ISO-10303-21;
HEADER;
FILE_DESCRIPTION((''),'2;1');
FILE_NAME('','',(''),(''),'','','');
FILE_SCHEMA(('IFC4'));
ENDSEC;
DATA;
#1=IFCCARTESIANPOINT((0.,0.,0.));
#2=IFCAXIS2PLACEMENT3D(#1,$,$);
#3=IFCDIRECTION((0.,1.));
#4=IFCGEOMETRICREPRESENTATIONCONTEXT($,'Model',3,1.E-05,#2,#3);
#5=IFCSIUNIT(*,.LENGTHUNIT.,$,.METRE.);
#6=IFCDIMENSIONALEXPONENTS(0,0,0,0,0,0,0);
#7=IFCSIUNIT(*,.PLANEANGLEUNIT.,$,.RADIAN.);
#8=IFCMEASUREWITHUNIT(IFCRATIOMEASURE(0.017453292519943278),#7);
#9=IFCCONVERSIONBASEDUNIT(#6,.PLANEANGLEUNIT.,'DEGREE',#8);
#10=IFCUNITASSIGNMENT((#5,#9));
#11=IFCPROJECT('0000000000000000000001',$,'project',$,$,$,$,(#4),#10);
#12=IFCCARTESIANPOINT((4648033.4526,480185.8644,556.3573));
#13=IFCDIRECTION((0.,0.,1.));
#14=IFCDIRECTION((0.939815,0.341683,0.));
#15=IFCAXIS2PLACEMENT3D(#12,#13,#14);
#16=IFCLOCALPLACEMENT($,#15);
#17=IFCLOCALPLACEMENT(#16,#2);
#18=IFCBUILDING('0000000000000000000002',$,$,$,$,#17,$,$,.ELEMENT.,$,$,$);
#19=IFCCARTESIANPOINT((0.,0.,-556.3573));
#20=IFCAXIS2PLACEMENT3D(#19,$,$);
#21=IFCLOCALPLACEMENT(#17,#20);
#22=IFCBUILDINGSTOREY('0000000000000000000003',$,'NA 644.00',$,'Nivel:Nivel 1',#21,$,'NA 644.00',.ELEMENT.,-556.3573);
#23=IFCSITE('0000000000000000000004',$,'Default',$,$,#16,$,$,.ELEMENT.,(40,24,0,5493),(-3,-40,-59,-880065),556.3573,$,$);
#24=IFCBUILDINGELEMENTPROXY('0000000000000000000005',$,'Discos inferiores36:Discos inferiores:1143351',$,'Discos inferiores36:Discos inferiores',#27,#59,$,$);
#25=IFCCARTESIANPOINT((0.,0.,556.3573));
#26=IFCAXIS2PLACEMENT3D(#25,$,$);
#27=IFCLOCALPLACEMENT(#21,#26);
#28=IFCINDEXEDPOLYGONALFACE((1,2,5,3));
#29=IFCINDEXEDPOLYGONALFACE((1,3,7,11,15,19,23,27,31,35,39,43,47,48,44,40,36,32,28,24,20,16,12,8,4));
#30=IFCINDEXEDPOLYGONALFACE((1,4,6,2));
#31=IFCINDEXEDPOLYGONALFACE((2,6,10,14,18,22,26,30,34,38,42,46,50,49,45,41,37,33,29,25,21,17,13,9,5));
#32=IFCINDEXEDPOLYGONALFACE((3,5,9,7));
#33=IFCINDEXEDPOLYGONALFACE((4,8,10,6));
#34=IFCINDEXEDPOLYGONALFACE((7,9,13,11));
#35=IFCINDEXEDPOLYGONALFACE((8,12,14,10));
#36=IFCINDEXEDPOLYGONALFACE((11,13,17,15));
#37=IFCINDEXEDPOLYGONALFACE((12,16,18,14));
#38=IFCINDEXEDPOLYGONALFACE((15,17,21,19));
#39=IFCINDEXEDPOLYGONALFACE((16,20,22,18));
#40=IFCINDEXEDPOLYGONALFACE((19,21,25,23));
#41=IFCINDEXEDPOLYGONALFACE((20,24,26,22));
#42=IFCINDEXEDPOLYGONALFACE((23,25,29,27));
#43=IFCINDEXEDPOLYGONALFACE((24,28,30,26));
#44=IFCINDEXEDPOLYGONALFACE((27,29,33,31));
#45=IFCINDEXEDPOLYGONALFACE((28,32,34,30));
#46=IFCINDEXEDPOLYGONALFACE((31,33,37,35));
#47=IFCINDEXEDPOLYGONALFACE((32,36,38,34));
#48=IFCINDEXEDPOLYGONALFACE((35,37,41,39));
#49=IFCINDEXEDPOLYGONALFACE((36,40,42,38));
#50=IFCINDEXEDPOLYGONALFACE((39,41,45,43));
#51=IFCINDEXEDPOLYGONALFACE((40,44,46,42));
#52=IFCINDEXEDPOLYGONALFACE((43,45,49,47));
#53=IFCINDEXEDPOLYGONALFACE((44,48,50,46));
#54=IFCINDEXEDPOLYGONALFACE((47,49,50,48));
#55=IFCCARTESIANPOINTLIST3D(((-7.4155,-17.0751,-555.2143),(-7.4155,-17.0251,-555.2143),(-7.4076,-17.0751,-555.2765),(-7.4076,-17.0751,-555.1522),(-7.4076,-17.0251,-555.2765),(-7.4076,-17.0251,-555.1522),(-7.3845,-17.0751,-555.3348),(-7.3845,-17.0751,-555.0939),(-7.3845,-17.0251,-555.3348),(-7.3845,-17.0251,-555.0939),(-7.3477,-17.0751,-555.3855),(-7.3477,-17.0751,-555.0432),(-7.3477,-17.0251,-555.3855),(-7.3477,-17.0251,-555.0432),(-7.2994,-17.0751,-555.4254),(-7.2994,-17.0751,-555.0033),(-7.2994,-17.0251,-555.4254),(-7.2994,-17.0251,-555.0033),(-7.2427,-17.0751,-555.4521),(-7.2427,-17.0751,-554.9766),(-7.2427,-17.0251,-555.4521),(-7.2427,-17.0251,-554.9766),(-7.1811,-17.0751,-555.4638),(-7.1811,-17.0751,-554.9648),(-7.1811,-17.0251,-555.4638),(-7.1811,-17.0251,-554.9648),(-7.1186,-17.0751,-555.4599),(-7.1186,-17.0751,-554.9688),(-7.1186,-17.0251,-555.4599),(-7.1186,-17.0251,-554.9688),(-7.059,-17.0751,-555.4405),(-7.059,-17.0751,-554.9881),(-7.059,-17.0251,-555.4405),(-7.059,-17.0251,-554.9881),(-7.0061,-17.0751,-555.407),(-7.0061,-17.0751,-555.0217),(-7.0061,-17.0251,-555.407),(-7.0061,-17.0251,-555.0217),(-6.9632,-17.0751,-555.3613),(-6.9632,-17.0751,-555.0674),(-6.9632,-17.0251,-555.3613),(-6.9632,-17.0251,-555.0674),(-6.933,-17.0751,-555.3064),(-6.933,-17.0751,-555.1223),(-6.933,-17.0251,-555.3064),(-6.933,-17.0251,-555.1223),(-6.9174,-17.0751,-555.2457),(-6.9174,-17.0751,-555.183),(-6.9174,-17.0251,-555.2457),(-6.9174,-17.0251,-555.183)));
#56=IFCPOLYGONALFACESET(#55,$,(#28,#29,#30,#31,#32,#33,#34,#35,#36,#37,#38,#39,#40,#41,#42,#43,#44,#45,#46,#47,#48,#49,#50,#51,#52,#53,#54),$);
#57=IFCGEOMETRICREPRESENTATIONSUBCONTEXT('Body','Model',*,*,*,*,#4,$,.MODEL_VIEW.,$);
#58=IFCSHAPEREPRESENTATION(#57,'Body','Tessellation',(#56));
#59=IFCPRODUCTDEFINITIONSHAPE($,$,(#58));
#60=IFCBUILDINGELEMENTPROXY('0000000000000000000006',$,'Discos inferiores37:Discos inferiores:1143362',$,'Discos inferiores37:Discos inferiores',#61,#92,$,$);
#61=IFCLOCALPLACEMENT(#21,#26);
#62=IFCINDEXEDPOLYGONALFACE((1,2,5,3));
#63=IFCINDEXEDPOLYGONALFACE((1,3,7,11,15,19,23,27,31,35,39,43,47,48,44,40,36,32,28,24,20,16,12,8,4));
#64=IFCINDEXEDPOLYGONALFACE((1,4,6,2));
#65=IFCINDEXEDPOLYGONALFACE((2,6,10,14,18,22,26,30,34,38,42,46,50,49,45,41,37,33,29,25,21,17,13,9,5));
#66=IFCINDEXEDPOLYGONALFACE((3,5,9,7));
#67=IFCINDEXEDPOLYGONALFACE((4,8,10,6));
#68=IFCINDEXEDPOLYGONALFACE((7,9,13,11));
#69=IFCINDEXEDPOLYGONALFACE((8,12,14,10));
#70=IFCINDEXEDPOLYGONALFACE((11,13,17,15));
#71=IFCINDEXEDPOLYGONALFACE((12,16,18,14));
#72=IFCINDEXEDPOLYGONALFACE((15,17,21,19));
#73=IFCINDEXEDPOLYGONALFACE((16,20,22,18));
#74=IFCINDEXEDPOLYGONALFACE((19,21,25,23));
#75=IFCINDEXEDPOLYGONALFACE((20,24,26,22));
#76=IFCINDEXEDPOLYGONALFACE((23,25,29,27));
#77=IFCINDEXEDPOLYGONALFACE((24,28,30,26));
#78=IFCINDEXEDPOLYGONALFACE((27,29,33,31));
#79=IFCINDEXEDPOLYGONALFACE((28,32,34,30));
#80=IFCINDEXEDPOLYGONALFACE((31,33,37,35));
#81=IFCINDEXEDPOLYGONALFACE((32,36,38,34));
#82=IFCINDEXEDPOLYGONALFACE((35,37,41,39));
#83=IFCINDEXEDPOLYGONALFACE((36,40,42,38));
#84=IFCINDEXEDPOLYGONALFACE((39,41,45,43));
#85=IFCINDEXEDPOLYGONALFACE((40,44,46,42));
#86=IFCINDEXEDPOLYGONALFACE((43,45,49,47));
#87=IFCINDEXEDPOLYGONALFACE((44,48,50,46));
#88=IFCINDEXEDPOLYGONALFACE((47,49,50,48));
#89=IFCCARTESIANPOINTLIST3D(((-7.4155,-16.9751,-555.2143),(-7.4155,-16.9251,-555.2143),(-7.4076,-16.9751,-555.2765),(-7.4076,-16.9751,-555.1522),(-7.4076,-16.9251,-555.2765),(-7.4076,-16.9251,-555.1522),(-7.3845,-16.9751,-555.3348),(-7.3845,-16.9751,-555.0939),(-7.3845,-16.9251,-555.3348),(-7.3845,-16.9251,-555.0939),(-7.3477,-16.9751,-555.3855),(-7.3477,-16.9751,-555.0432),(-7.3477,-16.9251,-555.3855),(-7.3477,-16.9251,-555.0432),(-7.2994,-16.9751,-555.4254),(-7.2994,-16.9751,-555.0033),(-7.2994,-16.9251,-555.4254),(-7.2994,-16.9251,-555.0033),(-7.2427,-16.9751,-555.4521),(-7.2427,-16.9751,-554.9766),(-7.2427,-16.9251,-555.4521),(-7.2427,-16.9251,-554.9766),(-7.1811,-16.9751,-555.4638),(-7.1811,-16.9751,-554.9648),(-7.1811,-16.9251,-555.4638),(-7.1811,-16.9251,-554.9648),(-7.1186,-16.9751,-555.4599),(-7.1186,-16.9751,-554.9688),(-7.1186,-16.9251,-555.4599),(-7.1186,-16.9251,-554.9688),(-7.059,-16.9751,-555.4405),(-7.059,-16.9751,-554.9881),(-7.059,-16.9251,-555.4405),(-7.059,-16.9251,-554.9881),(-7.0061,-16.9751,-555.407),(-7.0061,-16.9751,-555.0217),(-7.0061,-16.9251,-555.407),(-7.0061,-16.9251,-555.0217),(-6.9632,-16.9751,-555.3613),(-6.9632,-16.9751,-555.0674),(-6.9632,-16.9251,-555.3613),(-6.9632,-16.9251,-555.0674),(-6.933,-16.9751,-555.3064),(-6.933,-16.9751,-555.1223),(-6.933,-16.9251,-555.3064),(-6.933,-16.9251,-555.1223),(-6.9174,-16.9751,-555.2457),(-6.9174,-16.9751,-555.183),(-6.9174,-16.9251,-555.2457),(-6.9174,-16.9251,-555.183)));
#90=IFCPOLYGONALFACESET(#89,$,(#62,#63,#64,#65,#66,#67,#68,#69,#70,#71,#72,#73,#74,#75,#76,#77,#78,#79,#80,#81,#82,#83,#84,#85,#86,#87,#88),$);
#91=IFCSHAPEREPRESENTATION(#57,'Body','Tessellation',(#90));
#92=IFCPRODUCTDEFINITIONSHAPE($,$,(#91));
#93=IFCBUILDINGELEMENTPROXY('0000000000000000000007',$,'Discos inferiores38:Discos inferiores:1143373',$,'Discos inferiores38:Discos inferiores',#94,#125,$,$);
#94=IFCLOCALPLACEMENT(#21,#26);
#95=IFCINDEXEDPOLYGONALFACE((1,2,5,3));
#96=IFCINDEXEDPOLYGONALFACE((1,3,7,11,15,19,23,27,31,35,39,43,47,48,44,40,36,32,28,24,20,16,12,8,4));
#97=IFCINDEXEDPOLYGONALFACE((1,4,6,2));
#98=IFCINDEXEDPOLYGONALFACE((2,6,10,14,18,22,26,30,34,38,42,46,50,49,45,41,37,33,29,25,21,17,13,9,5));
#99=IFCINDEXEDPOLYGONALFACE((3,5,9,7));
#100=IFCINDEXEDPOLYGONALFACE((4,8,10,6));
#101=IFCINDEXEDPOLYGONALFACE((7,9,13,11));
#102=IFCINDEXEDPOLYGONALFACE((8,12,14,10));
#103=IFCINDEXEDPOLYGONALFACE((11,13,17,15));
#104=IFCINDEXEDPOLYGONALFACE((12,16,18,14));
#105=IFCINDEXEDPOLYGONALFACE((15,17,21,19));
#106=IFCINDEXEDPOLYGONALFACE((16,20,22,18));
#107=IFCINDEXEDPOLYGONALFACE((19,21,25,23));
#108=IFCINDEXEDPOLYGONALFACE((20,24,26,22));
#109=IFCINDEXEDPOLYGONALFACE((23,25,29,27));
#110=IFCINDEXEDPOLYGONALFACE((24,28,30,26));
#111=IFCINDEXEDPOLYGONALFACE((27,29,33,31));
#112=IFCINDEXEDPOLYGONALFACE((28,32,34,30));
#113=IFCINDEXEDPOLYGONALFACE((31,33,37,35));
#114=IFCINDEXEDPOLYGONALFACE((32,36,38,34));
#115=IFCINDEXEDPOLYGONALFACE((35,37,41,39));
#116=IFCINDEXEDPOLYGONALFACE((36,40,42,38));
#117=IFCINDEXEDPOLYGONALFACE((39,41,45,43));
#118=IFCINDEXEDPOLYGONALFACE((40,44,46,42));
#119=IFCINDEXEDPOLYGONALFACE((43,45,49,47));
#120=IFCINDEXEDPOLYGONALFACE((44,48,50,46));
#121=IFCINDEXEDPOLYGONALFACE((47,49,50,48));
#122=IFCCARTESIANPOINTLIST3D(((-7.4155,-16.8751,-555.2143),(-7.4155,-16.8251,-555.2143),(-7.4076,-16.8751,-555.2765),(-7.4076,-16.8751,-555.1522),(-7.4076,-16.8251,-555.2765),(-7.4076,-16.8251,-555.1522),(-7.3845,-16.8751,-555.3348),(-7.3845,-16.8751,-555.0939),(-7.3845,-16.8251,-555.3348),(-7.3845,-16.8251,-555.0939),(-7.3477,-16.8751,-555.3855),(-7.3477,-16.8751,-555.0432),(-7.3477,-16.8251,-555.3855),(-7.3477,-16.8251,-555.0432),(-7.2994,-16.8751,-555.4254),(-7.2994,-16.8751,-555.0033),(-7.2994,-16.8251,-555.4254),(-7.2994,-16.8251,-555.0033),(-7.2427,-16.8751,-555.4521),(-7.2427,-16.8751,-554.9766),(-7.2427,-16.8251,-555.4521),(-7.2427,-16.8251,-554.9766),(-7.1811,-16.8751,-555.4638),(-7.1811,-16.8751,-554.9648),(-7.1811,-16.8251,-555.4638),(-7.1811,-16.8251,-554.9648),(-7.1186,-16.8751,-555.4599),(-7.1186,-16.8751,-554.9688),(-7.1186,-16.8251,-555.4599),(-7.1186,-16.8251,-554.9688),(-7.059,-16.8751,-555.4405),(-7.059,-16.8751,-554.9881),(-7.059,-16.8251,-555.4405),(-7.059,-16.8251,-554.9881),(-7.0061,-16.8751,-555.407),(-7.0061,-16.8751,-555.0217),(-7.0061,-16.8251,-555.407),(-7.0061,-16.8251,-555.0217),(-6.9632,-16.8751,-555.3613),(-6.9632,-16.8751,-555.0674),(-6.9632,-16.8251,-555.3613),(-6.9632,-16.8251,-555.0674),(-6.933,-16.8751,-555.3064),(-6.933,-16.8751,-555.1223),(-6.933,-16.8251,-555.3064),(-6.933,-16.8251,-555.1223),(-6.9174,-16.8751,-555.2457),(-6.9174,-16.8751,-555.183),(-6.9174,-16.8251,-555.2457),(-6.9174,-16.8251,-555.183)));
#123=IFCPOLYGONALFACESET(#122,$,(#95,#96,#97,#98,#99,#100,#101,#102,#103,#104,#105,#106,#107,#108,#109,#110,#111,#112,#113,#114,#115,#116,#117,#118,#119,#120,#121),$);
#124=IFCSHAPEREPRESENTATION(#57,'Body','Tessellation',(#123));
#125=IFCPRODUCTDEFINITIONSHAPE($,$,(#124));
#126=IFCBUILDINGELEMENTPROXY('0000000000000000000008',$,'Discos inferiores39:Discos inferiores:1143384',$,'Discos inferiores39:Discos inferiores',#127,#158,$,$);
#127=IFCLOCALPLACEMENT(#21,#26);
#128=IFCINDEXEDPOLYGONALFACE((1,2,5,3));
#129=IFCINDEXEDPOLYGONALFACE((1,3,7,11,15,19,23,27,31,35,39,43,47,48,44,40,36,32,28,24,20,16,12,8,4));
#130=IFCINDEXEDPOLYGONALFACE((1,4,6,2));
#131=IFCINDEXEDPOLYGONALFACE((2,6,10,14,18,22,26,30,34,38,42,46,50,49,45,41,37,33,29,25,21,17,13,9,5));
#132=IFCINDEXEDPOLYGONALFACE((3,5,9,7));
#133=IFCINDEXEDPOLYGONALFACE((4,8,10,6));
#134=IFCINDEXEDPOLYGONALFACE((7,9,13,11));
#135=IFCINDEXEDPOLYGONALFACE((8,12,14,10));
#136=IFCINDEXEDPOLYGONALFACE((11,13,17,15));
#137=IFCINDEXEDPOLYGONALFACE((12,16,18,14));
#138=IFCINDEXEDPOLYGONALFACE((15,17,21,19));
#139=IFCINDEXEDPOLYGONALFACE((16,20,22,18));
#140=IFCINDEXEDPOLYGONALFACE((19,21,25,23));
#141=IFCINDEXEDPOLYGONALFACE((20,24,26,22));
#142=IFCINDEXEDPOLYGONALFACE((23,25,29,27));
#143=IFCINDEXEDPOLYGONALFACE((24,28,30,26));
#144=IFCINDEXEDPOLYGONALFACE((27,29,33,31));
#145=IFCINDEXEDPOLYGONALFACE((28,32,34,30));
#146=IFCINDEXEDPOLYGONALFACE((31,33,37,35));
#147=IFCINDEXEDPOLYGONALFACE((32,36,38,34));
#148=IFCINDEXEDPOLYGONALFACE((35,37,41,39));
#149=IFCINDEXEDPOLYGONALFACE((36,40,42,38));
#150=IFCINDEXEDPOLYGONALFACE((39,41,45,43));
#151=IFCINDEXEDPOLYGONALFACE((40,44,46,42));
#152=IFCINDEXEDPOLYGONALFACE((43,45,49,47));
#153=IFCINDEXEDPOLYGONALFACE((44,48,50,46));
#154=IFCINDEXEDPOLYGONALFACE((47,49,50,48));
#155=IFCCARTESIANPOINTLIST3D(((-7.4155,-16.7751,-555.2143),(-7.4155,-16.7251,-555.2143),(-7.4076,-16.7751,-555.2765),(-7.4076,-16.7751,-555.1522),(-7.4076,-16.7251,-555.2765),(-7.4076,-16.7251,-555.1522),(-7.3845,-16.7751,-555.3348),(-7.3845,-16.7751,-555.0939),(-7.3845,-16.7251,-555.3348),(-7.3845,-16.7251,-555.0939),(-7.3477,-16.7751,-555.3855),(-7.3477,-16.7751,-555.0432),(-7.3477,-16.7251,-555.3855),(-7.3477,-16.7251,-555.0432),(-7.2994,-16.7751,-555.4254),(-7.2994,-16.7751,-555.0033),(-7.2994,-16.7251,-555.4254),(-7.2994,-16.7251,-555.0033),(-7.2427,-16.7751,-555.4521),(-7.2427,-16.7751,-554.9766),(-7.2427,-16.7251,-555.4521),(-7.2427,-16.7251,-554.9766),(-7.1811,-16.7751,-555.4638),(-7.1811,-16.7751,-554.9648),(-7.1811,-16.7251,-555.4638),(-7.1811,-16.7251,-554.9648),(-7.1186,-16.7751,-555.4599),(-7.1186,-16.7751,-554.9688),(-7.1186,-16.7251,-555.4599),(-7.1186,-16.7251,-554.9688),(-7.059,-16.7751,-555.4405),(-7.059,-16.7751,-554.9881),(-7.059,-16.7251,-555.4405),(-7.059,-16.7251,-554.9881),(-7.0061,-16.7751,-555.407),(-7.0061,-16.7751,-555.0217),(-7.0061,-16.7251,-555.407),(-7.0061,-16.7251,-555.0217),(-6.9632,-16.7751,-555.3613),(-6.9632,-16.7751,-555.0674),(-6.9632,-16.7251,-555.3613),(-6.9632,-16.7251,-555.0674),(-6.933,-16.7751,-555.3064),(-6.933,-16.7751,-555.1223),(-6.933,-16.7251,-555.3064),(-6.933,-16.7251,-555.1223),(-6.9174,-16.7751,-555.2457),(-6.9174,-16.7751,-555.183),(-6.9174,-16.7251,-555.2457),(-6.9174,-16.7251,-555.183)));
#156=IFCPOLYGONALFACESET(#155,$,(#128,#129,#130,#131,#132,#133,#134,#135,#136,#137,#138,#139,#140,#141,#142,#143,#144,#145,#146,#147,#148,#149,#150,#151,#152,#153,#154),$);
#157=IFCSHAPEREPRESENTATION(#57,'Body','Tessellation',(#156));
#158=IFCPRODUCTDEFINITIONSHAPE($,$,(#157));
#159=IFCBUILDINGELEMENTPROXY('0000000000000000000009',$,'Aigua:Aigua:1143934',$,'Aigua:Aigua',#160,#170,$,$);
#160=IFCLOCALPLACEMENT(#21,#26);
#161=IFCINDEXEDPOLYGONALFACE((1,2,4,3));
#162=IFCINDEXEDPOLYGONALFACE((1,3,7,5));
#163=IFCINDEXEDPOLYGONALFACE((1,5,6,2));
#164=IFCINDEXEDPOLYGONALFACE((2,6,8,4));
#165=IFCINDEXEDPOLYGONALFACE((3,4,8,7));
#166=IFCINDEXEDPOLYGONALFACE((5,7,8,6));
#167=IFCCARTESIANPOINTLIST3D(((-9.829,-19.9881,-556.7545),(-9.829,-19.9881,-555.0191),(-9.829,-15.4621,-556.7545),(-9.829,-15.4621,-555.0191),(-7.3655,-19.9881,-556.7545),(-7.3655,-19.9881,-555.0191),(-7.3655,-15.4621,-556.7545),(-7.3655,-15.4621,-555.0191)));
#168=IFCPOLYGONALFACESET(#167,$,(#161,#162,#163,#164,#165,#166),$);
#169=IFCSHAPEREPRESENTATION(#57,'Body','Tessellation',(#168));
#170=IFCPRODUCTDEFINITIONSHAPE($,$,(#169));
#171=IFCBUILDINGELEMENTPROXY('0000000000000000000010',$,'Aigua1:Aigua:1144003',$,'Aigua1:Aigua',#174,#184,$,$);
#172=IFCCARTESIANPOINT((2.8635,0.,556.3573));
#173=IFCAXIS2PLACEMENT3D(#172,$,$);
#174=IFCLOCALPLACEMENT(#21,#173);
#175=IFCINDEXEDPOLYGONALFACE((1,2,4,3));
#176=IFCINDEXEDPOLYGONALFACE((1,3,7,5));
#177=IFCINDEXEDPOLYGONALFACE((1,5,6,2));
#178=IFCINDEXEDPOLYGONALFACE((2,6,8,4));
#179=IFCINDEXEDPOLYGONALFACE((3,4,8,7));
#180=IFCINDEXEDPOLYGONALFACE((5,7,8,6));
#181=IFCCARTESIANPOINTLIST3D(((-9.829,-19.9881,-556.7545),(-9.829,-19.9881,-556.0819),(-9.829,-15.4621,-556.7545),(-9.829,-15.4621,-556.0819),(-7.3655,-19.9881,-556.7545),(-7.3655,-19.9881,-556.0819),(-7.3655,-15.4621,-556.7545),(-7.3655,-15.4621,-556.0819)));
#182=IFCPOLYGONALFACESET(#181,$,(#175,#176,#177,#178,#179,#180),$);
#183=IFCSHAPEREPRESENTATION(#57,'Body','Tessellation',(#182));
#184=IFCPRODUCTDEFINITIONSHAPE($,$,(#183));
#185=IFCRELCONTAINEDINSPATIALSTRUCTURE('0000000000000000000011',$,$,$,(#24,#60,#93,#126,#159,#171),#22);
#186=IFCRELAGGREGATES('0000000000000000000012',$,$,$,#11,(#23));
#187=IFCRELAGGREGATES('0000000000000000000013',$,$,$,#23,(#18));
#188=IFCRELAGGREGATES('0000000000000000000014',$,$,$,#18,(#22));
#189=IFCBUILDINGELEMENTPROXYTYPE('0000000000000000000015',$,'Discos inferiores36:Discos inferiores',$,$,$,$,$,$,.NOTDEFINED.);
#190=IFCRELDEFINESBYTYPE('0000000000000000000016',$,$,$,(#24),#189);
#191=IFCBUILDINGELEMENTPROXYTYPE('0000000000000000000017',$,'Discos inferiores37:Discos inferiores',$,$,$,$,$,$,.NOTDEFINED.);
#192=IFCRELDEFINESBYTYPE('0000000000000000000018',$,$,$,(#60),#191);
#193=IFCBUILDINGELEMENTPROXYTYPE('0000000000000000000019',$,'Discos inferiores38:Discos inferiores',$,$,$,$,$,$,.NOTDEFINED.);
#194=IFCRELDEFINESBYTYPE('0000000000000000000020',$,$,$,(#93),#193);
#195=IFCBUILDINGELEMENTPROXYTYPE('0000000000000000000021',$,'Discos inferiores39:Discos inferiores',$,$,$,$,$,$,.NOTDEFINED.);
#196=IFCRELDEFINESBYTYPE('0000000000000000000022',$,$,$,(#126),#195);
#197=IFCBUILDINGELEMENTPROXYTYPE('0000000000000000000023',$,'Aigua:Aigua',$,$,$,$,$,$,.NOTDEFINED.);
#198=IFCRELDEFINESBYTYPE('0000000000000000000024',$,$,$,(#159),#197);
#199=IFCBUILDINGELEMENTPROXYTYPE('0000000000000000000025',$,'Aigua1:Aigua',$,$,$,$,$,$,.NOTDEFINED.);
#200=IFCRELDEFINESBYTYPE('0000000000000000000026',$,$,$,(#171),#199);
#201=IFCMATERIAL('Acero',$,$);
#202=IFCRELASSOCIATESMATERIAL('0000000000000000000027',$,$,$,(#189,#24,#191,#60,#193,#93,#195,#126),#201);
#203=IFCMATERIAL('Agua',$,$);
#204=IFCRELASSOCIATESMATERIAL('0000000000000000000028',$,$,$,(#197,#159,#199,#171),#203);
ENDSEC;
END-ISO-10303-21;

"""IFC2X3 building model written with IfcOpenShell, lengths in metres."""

from ifc_helpers import new_model, entity, si_unit, converted_unit, direction, frame, frame_2d, origin, origin_2d_with_axis, place, context, subcontext, project, spatial, rectangle, circle, extrude, source, transform, mapped, material, type_object, type_shapes, element, save


model = new_model("IFC2X3")

# Units and contexts
model_context = context("Model", 3, precision=1e-05, world=origin(), true_north=direction((0.0, 1.0)))
body_context = subcontext(model_context, "Body", "Model", "MODEL_VIEW")
ifc_project = project(units=[si_unit("LENGTHUNIT", "METRE"), converted_unit("PLANEANGLEUNIT", "DEGREE", entity("IfcRatioMeasure", 0.017453292519943278), si_unit("PLANEANGLEUNIT", "RADIAN"), dimensions=[0, 0, 0, 0, 0, 0, 0])], contexts=[model_context])

# Site, building, storey
site_placement = place(None, frame((4648033.4526, 480185.8644, 556.3573), z_axis=(0.0, 0.0, 1.0), x_axis=(0.939815, 0.341683, 0.0)))
site = spatial("IfcSite", under=ifc_project, at=site_placement, Name="Default", CompositionType="ELEMENT", RefLatitude=(40, 24, 0, 5493), RefLongitude=(-3, -40, -59, -880065), RefElevation=556.3573)
building_placement = place(site_placement, origin())
building = spatial("IfcBuilding", under=site, at=building_placement, CompositionType="ELEMENT")
storey_placement = place(building_placement, frame((0.0, 0.0, -556.3573)))
storey = spatial("IfcBuildingStorey", under=building, at=storey_placement, Name="NA 644.00", ObjectType="Nivel:Nivel 1", LongName="NA 644.00", CompositionType="ELEMENT", Elevation=-556.3573)

# Building element proxies
ifc_material_1 = material(Name="Acero")
building_element_proxy_type_1 = type_object("IfcBuildingElementProxyType", Name="Discos inferiores36:Discos inferiores", PredefinedType="NOTDEFINED", material=ifc_material_1)
shared_shape_1 = source(origin(), body_context, "Body", "SweptSolid", [
    extrude(circle(Radius=0.25, at=origin_2d_with_axis()), frame((-7.1655, -17.0751, -555.2143), z_axis=(0.0, 1.0, 0.0), x_axis=(-1.0, 0.0, 0.0)), (0.0, 0.0, 1.0), 0.05),
])
type_shapes(building_element_proxy_type_1, [shared_shape_1])
proxy_1_placement = place(storey_placement, frame((0.0, 0.0, 556.3573)))
element("IfcBuildingElementProxy", 1, at=proxy_1_placement, inside=storey, type_object=building_element_proxy_type_1, material=ifc_material_1, Name="Discos inferiores36:Discos inferiores:1143351", ObjectType="Discos inferiores36:Discos inferiores", context=body_context, shape_type="MappedRepresentation", body=[
    mapped(shared_shape_1, transform((0.0, 0.0, 0.0), scale=1.0)),
])
building_element_proxy_type_2 = type_object("IfcBuildingElementProxyType", Name="Discos inferiores37:Discos inferiores", PredefinedType="NOTDEFINED", material=ifc_material_1)
shared_shape_2 = source(origin(), body_context, "Body", "SweptSolid", [
    extrude(circle(Radius=0.25, at=origin_2d_with_axis()), frame((-7.1655, -16.9751, -555.2143), z_axis=(0.0, 1.0, 0.0), x_axis=(-1.0, 0.0, 0.0)), (0.0, 0.0, 1.0), 0.05),
])
type_shapes(building_element_proxy_type_2, [shared_shape_2])
proxy_2_placement = place(storey_placement, frame((0.0, 0.0, 556.3573)))
element("IfcBuildingElementProxy", 2, at=proxy_2_placement, inside=storey, type_object=building_element_proxy_type_2, material=ifc_material_1, Name="Discos inferiores37:Discos inferiores:1143362", ObjectType="Discos inferiores37:Discos inferiores", context=body_context, shape_type="MappedRepresentation", body=[
    mapped(shared_shape_2, transform((0.0, 0.0, 0.0), scale=1.0)),
])
building_element_proxy_type_3 = type_object("IfcBuildingElementProxyType", Name="Discos inferiores38:Discos inferiores", PredefinedType="NOTDEFINED", material=ifc_material_1)
shared_shape_3 = source(origin(), body_context, "Body", "SweptSolid", [
    extrude(circle(Radius=0.25, at=origin_2d_with_axis()), frame((-7.1655, -16.8751, -555.2143), z_axis=(0.0, 1.0, 0.0), x_axis=(-1.0, 0.0, 0.0)), (0.0, 0.0, 1.0), 0.05),
])
type_shapes(building_element_proxy_type_3, [shared_shape_3])
proxy_3_placement = place(storey_placement, frame((0.0, 0.0, 556.3573)))
element("IfcBuildingElementProxy", 3, at=proxy_3_placement, inside=storey, type_object=building_element_proxy_type_3, material=ifc_material_1, Name="Discos inferiores38:Discos inferiores:1143373", ObjectType="Discos inferiores38:Discos inferiores", context=body_context, shape_type="MappedRepresentation", body=[
    mapped(shared_shape_3, transform((0.0, 0.0, 0.0), scale=1.0)),
])
building_element_proxy_type_4 = type_object("IfcBuildingElementProxyType", Name="Discos inferiores39:Discos inferiores", PredefinedType="NOTDEFINED", material=ifc_material_1)
shared_shape_4 = source(origin(), body_context, "Body", "SweptSolid", [
    extrude(circle(Radius=0.25, at=origin_2d_with_axis()), frame((-7.1655, -16.7751, -555.2143), z_axis=(0.0, 1.0, 0.0), x_axis=(-1.0, 0.0, 0.0)), (0.0, 0.0, 1.0), 0.05),
])
type_shapes(building_element_proxy_type_4, [shared_shape_4])
proxy_4_placement = place(storey_placement, frame((0.0, 0.0, 556.3573)))
element("IfcBuildingElementProxy", 4, at=proxy_4_placement, inside=storey, type_object=building_element_proxy_type_4, material=ifc_material_1, Name="Discos inferiores39:Discos inferiores:1143384", ObjectType="Discos inferiores39:Discos inferiores", context=body_context, shape_type="MappedRepresentation", body=[
    mapped(shared_shape_4, transform((0.0, 0.0, 0.0), scale=1.0)),
])
ifc_material_2 = material(Name="Agua")
building_element_proxy_type_5 = type_object("IfcBuildingElementProxyType", Name="Aigua:Aigua", PredefinedType="NOTDEFINED", material=ifc_material_2)
shared_shape_5 = source(origin(), body_context, "Body", "SweptSolid", [
    extrude(rectangle(XDim=2.4635, YDim=4.526, at=frame_2d((0.0, 0.0), x_axis=(1.0, 0.0))), frame((-8.5972, -17.7251, -556.7545), z_axis=(0.0, 0.0, 1.0), x_axis=(-1.0, 0.0, 0.0)), (0.0, 0.0, 1.0), 1.7354),
])
type_shapes(building_element_proxy_type_5, [shared_shape_5])
proxy_5_placement = place(storey_placement, frame((0.0, 0.0, 556.3573)))
element("IfcBuildingElementProxy", 5, at=proxy_5_placement, inside=storey, type_object=building_element_proxy_type_5, material=ifc_material_2, Name="Aigua:Aigua:1143934", ObjectType="Aigua:Aigua", context=body_context, shape_type="MappedRepresentation", body=[
    mapped(shared_shape_5, transform((0.0, 0.0, 0.0), scale=1.0)),
])
building_element_proxy_type_6 = type_object("IfcBuildingElementProxyType", Name="Aigua1:Aigua", PredefinedType="NOTDEFINED", material=ifc_material_2)
shared_shape_6 = source(origin(), body_context, "Body", "SweptSolid", [
    extrude(rectangle(XDim=2.4635, YDim=4.526, at=frame_2d((0.0, 0.0), x_axis=(1.0, 0.0))), frame((-8.5972, -17.7251, -556.7545), z_axis=(0.0, 0.0, 1.0), x_axis=(-1.0, 0.0, 0.0)), (0.0, 0.0, 1.0), 0.6725),
])
type_shapes(building_element_proxy_type_6, [shared_shape_6])
proxy_6_placement = place(storey_placement, frame((2.8635, 0.0, 556.3573)))
element("IfcBuildingElementProxy", 6, at=proxy_6_placement, inside=storey, type_object=building_element_proxy_type_6, material=ifc_material_2, Name="Aigua1:Aigua:1144003", ObjectType="Aigua1:Aigua", context=body_context, shape_type="MappedRepresentation", body=[
    mapped(shared_shape_6, transform((0.0, 0.0, 0.0), scale=1.0)),
])

save(model, "model.ifc")
